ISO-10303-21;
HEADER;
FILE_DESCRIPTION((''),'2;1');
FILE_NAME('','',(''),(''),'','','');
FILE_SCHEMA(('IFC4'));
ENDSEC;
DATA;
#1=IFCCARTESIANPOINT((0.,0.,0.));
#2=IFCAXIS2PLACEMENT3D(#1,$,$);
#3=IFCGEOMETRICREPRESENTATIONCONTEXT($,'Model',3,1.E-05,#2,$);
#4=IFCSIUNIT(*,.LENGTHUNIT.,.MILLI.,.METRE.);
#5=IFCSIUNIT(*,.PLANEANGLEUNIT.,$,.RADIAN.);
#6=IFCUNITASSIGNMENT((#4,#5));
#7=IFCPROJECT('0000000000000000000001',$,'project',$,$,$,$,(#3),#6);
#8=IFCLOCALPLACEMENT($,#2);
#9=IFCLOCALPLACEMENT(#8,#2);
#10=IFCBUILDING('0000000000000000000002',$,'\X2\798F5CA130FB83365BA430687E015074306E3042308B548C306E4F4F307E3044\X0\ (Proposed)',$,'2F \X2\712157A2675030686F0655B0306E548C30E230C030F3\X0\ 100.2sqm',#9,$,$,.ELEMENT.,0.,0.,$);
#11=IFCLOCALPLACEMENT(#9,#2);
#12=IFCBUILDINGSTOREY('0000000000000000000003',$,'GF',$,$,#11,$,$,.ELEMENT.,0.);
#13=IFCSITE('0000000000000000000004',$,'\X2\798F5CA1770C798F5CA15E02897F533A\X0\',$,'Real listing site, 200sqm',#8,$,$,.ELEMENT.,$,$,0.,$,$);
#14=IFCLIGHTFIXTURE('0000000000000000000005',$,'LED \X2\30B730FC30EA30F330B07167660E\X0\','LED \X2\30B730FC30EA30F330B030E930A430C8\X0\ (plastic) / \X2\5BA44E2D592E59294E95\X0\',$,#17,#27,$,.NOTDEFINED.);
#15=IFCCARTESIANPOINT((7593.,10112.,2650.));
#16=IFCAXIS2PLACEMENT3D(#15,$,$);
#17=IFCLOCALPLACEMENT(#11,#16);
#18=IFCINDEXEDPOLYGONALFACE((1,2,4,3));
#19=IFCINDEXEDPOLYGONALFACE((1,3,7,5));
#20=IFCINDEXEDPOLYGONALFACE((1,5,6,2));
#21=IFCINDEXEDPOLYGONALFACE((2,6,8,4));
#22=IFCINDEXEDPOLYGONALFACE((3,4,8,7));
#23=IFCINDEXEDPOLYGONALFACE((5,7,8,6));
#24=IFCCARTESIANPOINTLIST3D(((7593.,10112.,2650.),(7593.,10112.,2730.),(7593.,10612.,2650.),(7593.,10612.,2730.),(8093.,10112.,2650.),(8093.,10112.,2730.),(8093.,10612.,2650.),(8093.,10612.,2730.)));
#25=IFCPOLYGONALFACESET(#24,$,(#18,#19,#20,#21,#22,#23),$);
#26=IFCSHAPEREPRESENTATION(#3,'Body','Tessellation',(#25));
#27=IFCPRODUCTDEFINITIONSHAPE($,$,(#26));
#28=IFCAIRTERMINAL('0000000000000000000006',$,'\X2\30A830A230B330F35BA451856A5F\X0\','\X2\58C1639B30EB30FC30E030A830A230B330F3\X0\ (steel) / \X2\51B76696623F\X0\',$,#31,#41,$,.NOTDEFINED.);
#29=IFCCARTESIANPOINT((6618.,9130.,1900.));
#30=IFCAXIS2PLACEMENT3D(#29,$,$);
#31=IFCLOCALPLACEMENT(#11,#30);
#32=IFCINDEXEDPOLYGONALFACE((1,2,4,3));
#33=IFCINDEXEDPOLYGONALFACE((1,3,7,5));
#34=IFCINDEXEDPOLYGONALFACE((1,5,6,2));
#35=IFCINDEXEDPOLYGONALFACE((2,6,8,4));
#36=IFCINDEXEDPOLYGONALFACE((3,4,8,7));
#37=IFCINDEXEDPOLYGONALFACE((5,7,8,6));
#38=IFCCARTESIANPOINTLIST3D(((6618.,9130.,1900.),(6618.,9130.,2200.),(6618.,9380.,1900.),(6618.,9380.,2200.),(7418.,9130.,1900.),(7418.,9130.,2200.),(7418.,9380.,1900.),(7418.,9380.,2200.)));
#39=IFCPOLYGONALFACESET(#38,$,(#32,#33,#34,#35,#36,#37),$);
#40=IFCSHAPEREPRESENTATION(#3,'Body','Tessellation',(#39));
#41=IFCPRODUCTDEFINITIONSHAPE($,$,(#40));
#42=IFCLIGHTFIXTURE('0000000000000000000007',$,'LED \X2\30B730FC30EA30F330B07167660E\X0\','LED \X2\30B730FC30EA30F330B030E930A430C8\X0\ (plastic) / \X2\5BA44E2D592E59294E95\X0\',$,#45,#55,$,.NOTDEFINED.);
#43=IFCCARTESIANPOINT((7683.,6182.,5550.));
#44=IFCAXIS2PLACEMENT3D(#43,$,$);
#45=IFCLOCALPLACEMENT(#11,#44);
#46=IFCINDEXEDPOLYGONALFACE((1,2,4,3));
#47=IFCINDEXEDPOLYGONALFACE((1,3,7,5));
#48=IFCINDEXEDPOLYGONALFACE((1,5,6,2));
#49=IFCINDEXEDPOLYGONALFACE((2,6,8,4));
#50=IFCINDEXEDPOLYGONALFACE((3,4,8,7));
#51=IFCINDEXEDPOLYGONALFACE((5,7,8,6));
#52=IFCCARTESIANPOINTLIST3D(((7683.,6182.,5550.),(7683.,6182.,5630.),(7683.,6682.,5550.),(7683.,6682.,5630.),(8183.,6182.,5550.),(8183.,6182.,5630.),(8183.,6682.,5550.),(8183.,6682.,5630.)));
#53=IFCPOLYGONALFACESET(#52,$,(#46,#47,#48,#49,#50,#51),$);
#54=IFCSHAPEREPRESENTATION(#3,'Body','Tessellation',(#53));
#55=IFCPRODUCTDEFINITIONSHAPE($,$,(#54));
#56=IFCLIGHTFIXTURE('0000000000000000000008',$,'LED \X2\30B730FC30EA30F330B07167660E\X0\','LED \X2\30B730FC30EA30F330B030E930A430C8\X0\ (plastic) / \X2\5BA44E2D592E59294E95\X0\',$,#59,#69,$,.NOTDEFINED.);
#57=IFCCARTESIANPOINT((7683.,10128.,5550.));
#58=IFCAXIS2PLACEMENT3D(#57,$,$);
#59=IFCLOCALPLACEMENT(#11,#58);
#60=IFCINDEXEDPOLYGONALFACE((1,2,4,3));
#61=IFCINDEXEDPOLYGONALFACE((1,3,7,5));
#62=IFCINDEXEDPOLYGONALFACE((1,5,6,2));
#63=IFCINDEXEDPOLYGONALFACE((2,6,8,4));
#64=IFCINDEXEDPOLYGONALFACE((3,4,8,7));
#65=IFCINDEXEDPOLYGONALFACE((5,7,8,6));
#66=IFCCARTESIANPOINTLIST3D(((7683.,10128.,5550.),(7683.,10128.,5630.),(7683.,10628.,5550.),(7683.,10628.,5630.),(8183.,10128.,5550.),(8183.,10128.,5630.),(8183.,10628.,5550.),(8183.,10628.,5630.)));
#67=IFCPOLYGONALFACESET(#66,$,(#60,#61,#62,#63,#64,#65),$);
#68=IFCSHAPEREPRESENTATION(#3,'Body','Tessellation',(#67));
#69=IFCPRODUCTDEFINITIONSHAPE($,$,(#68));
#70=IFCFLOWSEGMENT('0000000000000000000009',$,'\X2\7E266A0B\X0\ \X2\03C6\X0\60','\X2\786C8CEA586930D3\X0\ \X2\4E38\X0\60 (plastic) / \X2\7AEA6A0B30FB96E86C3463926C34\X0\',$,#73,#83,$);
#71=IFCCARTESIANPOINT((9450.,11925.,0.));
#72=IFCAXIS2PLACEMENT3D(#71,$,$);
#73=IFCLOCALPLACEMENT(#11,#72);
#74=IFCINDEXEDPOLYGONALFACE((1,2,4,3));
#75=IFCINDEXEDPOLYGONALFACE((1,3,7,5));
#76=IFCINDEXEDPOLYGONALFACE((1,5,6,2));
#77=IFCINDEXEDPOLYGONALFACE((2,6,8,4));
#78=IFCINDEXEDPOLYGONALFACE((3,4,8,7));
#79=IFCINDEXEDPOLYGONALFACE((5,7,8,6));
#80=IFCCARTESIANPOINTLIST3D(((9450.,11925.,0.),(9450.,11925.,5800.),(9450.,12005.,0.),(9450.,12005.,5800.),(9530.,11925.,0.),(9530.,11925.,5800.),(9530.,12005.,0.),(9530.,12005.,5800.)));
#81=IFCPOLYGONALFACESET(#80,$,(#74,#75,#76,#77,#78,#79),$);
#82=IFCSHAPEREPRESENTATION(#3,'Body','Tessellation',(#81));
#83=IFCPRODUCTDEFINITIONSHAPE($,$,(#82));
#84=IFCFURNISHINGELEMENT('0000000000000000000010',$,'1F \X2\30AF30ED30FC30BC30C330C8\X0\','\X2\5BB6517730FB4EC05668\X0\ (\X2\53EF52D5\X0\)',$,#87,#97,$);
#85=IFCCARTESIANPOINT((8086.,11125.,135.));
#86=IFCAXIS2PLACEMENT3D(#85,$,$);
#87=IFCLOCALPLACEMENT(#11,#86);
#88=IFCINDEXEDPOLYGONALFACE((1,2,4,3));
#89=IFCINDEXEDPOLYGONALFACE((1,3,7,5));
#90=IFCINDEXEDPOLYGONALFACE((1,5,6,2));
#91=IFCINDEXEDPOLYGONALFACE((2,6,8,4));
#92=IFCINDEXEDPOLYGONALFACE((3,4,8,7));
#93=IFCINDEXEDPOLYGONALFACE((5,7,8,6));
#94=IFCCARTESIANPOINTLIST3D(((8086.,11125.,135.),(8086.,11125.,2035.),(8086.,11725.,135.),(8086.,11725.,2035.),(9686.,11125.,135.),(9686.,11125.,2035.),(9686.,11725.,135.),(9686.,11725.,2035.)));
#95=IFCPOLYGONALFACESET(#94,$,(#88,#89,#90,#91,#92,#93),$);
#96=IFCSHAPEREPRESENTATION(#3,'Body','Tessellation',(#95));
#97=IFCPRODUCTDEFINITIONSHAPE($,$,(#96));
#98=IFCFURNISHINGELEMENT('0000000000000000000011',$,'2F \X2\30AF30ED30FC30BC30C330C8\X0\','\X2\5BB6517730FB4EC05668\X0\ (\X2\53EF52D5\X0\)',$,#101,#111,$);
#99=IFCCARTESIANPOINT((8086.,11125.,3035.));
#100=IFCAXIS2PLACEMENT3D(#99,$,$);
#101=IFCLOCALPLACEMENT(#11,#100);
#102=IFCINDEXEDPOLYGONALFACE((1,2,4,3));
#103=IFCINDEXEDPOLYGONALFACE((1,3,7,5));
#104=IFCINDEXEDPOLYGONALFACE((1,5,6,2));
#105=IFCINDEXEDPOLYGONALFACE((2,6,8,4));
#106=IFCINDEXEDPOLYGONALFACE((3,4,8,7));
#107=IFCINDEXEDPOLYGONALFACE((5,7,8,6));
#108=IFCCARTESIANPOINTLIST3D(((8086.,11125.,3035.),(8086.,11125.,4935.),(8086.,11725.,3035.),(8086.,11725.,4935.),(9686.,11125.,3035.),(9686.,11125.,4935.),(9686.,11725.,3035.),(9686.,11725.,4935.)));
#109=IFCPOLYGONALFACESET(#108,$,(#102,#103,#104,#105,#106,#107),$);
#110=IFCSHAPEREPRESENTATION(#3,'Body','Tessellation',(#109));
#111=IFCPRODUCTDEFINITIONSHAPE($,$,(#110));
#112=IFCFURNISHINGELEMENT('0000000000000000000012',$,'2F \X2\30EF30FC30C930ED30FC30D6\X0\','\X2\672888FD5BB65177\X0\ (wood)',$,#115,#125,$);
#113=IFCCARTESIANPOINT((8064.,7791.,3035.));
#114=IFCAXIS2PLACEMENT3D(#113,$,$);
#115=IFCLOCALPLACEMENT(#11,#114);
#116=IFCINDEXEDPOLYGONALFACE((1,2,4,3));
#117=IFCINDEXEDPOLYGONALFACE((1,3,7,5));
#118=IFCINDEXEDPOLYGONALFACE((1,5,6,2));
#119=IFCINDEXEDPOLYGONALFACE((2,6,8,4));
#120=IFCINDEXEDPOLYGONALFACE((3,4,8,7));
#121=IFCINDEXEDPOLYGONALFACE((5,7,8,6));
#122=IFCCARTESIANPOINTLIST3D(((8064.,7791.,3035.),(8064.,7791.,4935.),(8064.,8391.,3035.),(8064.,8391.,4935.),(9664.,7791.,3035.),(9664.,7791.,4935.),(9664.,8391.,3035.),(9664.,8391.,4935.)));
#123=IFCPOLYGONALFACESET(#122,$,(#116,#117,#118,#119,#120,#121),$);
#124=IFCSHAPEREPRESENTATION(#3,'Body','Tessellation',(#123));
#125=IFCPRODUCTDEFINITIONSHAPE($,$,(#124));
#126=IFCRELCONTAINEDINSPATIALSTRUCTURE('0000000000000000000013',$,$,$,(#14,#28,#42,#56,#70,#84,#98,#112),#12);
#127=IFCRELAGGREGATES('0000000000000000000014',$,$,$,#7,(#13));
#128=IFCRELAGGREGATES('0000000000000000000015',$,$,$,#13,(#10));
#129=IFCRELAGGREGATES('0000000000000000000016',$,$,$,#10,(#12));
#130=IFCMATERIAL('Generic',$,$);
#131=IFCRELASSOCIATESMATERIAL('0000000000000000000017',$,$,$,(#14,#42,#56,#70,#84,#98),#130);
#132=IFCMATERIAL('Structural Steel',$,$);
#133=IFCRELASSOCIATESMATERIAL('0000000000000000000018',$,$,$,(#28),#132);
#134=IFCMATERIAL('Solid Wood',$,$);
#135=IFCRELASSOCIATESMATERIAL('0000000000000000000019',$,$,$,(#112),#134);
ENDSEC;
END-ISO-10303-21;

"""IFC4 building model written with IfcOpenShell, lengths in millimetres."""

from ifc_helpers import new_model, si_unit, frame, frame_2d, origin, place, context, project, spatial, rectangle, extrude, material, element, save


model = new_model("IFC4")

# Units and contexts
model_context = context("Model", 3, precision=1e-05, world=origin())
ifc_project = project(units=[si_unit("LENGTHUNIT", "METRE", prefix="MILLI"), si_unit("PLANEANGLEUNIT", "RADIAN")], contexts=[model_context])

# Site, building, storey
site_placement = place(None, origin())
site = spatial("IfcSite", under=ifc_project, at=site_placement, Name="福岡県福岡市西区", ObjectType="Real listing site, 200sqm", CompositionType="ELEMENT", RefElevation=0.0)
building_placement = place(site_placement, origin())
building = spatial("IfcBuilding", under=site, at=building_placement, Name="福岡・茶室と縁側のある和の住まい (Proposed)", ObjectType="2F 無垢材と漆喰の和モダン 100.2sqm", CompositionType="ELEMENT", ElevationOfRefHeight=0.0, ElevationOfTerrain=0.0)
storey_placement = place(building_placement, origin())
storey = spatial("IfcBuildingStorey", under=building, at=storey_placement, Name="GF", CompositionType="ELEMENT", Elevation=0.0)

# Shared definitions
ifc_material_1 = material(Name="Solid Wood")

# Shared definitions
ifc_material_2 = material(Name="Structural Steel")

# Shared definitions
ifc_material_3 = material(Name="Generic")

# Light fixture
light_fixture_1_placement = place(storey_placement, frame((7593.0, 10112.0, 2650.0)))
element("IfcLightFixture", 1, at=light_fixture_1_placement, inside=storey, material=ifc_material_3, Name="LED シーリング照明", Description="LED シーリングライト (plastic) / 室中央天井", PredefinedType="NOTDEFINED", context=model_context, shape_type="SweptSolid", body=[
    extrude(rectangle(XDim=500.0, YDim=500.0, at=frame_2d((250.0, 250.0))), frame((7593.0, 10112.0, 2650.0)), (0.0, 0.0, 1.0), 80.0),
])

# Air terminal
air_terminal_placement = place(storey_placement, frame((6618.0, 9130.0, 1900.0)))
element("IfcAirTerminal", 2, at=air_terminal_placement, inside=storey, material=ifc_material_2, Name="エアコン室内機", Description="壁掛ルームエアコン (steel) / 冷暖房", PredefinedType="NOTDEFINED", context=model_context, shape_type="SweptSolid", body=[
    extrude(rectangle(XDim=800.0, YDim=250.0, at=frame_2d((400.0, 125.0))), frame((6618.0, 9130.0, 1900.0)), (0.0, 0.0, 1.0), 300.0),
])

# Light fixtures
light_fixture_2_placement = place(storey_placement, frame((7683.0, 6182.0, 5550.0)))
element("IfcLightFixture", 3, at=light_fixture_2_placement, inside=storey, material=ifc_material_3, Name="LED シーリング照明", Description="LED シーリングライト (plastic) / 室中央天井", PredefinedType="NOTDEFINED", context=model_context, shape_type="SweptSolid", body=[
    extrude(rectangle(XDim=500.0, YDim=500.0, at=frame_2d((250.0, 250.0))), frame((7683.0, 6182.0, 5550.0)), (0.0, 0.0, 1.0), 80.0),
])
light_fixture_3_placement = place(storey_placement, frame((7683.0, 10128.0, 5550.0)))
element("IfcLightFixture", 4, at=light_fixture_3_placement, inside=storey, material=ifc_material_3, Name="LED シーリング照明", Description="LED シーリングライト (plastic) / 室中央天井", PredefinedType="NOTDEFINED", context=model_context, shape_type="SweptSolid", body=[
    extrude(rectangle(XDim=500.0, YDim=500.0, at=frame_2d((250.0, 250.0))), frame((7683.0, 10128.0, 5550.0)), (0.0, 0.0, 1.0), 80.0),
])

# Flow segment
flow_segment_placement = place(storey_placement, frame((9450.0, 11925.0, 0.0)))
element("IfcFlowSegment", 5, at=flow_segment_placement, inside=storey, material=ifc_material_3, Name="縦樋 φ60", Description="硬質塩ビ 丸60 (plastic) / 竪樋・雨水排水", context=model_context, shape_type="SweptSolid", body=[
    extrude(rectangle(XDim=80.0, YDim=80.0, at=frame_2d((40.0, 40.0))), frame((9450.0, 11925.0, 0.0)), (0.0, 0.0, 1.0), 5800.0),
])

# Furnishing elements
furnishing_1_placement = place(storey_placement, frame((8086.0, 11125.0, 135.0)))
element("IfcFurnishingElement", 6, at=furnishing_1_placement, inside=storey, material=ifc_material_3, Name="1F クローゼット", Description="家具・什器 (可動)", context=model_context, shape_type="SweptSolid", body=[
    extrude(rectangle(XDim=1600.0, YDim=600.0, at=frame_2d((800.0, 300.0))), frame((8086.0, 11125.0, 135.0)), (0.0, 0.0, 1.0), 1900.0),
])
furnishing_2_placement = place(storey_placement, frame((8086.0, 11125.0, 3035.0)))
element("IfcFurnishingElement", 7, at=furnishing_2_placement, inside=storey, material=ifc_material_3, Name="2F クローゼット", Description="家具・什器 (可動)", context=model_context, shape_type="SweptSolid", body=[
    extrude(rectangle(XDim=1600.0, YDim=600.0, at=frame_2d((800.0, 300.0))), frame((8086.0, 11125.0, 3035.0)), (0.0, 0.0, 1.0), 1900.0),
])
furnishing_3_placement = place(storey_placement, frame((8064.0, 7791.0, 3035.0)))
element("IfcFurnishingElement", 8, at=furnishing_3_placement, inside=storey, material=ifc_material_1, Name="2F ワードローブ", Description="木製家具 (wood)", context=model_context, shape_type="SweptSolid", body=[
    extrude(rectangle(XDim=1600.0, YDim=600.0, at=frame_2d((800.0, 300.0))), frame((8064.0, 7791.0, 3035.0)), (0.0, 0.0, 1.0), 1900.0),
])

save(model, "model.ifc")
